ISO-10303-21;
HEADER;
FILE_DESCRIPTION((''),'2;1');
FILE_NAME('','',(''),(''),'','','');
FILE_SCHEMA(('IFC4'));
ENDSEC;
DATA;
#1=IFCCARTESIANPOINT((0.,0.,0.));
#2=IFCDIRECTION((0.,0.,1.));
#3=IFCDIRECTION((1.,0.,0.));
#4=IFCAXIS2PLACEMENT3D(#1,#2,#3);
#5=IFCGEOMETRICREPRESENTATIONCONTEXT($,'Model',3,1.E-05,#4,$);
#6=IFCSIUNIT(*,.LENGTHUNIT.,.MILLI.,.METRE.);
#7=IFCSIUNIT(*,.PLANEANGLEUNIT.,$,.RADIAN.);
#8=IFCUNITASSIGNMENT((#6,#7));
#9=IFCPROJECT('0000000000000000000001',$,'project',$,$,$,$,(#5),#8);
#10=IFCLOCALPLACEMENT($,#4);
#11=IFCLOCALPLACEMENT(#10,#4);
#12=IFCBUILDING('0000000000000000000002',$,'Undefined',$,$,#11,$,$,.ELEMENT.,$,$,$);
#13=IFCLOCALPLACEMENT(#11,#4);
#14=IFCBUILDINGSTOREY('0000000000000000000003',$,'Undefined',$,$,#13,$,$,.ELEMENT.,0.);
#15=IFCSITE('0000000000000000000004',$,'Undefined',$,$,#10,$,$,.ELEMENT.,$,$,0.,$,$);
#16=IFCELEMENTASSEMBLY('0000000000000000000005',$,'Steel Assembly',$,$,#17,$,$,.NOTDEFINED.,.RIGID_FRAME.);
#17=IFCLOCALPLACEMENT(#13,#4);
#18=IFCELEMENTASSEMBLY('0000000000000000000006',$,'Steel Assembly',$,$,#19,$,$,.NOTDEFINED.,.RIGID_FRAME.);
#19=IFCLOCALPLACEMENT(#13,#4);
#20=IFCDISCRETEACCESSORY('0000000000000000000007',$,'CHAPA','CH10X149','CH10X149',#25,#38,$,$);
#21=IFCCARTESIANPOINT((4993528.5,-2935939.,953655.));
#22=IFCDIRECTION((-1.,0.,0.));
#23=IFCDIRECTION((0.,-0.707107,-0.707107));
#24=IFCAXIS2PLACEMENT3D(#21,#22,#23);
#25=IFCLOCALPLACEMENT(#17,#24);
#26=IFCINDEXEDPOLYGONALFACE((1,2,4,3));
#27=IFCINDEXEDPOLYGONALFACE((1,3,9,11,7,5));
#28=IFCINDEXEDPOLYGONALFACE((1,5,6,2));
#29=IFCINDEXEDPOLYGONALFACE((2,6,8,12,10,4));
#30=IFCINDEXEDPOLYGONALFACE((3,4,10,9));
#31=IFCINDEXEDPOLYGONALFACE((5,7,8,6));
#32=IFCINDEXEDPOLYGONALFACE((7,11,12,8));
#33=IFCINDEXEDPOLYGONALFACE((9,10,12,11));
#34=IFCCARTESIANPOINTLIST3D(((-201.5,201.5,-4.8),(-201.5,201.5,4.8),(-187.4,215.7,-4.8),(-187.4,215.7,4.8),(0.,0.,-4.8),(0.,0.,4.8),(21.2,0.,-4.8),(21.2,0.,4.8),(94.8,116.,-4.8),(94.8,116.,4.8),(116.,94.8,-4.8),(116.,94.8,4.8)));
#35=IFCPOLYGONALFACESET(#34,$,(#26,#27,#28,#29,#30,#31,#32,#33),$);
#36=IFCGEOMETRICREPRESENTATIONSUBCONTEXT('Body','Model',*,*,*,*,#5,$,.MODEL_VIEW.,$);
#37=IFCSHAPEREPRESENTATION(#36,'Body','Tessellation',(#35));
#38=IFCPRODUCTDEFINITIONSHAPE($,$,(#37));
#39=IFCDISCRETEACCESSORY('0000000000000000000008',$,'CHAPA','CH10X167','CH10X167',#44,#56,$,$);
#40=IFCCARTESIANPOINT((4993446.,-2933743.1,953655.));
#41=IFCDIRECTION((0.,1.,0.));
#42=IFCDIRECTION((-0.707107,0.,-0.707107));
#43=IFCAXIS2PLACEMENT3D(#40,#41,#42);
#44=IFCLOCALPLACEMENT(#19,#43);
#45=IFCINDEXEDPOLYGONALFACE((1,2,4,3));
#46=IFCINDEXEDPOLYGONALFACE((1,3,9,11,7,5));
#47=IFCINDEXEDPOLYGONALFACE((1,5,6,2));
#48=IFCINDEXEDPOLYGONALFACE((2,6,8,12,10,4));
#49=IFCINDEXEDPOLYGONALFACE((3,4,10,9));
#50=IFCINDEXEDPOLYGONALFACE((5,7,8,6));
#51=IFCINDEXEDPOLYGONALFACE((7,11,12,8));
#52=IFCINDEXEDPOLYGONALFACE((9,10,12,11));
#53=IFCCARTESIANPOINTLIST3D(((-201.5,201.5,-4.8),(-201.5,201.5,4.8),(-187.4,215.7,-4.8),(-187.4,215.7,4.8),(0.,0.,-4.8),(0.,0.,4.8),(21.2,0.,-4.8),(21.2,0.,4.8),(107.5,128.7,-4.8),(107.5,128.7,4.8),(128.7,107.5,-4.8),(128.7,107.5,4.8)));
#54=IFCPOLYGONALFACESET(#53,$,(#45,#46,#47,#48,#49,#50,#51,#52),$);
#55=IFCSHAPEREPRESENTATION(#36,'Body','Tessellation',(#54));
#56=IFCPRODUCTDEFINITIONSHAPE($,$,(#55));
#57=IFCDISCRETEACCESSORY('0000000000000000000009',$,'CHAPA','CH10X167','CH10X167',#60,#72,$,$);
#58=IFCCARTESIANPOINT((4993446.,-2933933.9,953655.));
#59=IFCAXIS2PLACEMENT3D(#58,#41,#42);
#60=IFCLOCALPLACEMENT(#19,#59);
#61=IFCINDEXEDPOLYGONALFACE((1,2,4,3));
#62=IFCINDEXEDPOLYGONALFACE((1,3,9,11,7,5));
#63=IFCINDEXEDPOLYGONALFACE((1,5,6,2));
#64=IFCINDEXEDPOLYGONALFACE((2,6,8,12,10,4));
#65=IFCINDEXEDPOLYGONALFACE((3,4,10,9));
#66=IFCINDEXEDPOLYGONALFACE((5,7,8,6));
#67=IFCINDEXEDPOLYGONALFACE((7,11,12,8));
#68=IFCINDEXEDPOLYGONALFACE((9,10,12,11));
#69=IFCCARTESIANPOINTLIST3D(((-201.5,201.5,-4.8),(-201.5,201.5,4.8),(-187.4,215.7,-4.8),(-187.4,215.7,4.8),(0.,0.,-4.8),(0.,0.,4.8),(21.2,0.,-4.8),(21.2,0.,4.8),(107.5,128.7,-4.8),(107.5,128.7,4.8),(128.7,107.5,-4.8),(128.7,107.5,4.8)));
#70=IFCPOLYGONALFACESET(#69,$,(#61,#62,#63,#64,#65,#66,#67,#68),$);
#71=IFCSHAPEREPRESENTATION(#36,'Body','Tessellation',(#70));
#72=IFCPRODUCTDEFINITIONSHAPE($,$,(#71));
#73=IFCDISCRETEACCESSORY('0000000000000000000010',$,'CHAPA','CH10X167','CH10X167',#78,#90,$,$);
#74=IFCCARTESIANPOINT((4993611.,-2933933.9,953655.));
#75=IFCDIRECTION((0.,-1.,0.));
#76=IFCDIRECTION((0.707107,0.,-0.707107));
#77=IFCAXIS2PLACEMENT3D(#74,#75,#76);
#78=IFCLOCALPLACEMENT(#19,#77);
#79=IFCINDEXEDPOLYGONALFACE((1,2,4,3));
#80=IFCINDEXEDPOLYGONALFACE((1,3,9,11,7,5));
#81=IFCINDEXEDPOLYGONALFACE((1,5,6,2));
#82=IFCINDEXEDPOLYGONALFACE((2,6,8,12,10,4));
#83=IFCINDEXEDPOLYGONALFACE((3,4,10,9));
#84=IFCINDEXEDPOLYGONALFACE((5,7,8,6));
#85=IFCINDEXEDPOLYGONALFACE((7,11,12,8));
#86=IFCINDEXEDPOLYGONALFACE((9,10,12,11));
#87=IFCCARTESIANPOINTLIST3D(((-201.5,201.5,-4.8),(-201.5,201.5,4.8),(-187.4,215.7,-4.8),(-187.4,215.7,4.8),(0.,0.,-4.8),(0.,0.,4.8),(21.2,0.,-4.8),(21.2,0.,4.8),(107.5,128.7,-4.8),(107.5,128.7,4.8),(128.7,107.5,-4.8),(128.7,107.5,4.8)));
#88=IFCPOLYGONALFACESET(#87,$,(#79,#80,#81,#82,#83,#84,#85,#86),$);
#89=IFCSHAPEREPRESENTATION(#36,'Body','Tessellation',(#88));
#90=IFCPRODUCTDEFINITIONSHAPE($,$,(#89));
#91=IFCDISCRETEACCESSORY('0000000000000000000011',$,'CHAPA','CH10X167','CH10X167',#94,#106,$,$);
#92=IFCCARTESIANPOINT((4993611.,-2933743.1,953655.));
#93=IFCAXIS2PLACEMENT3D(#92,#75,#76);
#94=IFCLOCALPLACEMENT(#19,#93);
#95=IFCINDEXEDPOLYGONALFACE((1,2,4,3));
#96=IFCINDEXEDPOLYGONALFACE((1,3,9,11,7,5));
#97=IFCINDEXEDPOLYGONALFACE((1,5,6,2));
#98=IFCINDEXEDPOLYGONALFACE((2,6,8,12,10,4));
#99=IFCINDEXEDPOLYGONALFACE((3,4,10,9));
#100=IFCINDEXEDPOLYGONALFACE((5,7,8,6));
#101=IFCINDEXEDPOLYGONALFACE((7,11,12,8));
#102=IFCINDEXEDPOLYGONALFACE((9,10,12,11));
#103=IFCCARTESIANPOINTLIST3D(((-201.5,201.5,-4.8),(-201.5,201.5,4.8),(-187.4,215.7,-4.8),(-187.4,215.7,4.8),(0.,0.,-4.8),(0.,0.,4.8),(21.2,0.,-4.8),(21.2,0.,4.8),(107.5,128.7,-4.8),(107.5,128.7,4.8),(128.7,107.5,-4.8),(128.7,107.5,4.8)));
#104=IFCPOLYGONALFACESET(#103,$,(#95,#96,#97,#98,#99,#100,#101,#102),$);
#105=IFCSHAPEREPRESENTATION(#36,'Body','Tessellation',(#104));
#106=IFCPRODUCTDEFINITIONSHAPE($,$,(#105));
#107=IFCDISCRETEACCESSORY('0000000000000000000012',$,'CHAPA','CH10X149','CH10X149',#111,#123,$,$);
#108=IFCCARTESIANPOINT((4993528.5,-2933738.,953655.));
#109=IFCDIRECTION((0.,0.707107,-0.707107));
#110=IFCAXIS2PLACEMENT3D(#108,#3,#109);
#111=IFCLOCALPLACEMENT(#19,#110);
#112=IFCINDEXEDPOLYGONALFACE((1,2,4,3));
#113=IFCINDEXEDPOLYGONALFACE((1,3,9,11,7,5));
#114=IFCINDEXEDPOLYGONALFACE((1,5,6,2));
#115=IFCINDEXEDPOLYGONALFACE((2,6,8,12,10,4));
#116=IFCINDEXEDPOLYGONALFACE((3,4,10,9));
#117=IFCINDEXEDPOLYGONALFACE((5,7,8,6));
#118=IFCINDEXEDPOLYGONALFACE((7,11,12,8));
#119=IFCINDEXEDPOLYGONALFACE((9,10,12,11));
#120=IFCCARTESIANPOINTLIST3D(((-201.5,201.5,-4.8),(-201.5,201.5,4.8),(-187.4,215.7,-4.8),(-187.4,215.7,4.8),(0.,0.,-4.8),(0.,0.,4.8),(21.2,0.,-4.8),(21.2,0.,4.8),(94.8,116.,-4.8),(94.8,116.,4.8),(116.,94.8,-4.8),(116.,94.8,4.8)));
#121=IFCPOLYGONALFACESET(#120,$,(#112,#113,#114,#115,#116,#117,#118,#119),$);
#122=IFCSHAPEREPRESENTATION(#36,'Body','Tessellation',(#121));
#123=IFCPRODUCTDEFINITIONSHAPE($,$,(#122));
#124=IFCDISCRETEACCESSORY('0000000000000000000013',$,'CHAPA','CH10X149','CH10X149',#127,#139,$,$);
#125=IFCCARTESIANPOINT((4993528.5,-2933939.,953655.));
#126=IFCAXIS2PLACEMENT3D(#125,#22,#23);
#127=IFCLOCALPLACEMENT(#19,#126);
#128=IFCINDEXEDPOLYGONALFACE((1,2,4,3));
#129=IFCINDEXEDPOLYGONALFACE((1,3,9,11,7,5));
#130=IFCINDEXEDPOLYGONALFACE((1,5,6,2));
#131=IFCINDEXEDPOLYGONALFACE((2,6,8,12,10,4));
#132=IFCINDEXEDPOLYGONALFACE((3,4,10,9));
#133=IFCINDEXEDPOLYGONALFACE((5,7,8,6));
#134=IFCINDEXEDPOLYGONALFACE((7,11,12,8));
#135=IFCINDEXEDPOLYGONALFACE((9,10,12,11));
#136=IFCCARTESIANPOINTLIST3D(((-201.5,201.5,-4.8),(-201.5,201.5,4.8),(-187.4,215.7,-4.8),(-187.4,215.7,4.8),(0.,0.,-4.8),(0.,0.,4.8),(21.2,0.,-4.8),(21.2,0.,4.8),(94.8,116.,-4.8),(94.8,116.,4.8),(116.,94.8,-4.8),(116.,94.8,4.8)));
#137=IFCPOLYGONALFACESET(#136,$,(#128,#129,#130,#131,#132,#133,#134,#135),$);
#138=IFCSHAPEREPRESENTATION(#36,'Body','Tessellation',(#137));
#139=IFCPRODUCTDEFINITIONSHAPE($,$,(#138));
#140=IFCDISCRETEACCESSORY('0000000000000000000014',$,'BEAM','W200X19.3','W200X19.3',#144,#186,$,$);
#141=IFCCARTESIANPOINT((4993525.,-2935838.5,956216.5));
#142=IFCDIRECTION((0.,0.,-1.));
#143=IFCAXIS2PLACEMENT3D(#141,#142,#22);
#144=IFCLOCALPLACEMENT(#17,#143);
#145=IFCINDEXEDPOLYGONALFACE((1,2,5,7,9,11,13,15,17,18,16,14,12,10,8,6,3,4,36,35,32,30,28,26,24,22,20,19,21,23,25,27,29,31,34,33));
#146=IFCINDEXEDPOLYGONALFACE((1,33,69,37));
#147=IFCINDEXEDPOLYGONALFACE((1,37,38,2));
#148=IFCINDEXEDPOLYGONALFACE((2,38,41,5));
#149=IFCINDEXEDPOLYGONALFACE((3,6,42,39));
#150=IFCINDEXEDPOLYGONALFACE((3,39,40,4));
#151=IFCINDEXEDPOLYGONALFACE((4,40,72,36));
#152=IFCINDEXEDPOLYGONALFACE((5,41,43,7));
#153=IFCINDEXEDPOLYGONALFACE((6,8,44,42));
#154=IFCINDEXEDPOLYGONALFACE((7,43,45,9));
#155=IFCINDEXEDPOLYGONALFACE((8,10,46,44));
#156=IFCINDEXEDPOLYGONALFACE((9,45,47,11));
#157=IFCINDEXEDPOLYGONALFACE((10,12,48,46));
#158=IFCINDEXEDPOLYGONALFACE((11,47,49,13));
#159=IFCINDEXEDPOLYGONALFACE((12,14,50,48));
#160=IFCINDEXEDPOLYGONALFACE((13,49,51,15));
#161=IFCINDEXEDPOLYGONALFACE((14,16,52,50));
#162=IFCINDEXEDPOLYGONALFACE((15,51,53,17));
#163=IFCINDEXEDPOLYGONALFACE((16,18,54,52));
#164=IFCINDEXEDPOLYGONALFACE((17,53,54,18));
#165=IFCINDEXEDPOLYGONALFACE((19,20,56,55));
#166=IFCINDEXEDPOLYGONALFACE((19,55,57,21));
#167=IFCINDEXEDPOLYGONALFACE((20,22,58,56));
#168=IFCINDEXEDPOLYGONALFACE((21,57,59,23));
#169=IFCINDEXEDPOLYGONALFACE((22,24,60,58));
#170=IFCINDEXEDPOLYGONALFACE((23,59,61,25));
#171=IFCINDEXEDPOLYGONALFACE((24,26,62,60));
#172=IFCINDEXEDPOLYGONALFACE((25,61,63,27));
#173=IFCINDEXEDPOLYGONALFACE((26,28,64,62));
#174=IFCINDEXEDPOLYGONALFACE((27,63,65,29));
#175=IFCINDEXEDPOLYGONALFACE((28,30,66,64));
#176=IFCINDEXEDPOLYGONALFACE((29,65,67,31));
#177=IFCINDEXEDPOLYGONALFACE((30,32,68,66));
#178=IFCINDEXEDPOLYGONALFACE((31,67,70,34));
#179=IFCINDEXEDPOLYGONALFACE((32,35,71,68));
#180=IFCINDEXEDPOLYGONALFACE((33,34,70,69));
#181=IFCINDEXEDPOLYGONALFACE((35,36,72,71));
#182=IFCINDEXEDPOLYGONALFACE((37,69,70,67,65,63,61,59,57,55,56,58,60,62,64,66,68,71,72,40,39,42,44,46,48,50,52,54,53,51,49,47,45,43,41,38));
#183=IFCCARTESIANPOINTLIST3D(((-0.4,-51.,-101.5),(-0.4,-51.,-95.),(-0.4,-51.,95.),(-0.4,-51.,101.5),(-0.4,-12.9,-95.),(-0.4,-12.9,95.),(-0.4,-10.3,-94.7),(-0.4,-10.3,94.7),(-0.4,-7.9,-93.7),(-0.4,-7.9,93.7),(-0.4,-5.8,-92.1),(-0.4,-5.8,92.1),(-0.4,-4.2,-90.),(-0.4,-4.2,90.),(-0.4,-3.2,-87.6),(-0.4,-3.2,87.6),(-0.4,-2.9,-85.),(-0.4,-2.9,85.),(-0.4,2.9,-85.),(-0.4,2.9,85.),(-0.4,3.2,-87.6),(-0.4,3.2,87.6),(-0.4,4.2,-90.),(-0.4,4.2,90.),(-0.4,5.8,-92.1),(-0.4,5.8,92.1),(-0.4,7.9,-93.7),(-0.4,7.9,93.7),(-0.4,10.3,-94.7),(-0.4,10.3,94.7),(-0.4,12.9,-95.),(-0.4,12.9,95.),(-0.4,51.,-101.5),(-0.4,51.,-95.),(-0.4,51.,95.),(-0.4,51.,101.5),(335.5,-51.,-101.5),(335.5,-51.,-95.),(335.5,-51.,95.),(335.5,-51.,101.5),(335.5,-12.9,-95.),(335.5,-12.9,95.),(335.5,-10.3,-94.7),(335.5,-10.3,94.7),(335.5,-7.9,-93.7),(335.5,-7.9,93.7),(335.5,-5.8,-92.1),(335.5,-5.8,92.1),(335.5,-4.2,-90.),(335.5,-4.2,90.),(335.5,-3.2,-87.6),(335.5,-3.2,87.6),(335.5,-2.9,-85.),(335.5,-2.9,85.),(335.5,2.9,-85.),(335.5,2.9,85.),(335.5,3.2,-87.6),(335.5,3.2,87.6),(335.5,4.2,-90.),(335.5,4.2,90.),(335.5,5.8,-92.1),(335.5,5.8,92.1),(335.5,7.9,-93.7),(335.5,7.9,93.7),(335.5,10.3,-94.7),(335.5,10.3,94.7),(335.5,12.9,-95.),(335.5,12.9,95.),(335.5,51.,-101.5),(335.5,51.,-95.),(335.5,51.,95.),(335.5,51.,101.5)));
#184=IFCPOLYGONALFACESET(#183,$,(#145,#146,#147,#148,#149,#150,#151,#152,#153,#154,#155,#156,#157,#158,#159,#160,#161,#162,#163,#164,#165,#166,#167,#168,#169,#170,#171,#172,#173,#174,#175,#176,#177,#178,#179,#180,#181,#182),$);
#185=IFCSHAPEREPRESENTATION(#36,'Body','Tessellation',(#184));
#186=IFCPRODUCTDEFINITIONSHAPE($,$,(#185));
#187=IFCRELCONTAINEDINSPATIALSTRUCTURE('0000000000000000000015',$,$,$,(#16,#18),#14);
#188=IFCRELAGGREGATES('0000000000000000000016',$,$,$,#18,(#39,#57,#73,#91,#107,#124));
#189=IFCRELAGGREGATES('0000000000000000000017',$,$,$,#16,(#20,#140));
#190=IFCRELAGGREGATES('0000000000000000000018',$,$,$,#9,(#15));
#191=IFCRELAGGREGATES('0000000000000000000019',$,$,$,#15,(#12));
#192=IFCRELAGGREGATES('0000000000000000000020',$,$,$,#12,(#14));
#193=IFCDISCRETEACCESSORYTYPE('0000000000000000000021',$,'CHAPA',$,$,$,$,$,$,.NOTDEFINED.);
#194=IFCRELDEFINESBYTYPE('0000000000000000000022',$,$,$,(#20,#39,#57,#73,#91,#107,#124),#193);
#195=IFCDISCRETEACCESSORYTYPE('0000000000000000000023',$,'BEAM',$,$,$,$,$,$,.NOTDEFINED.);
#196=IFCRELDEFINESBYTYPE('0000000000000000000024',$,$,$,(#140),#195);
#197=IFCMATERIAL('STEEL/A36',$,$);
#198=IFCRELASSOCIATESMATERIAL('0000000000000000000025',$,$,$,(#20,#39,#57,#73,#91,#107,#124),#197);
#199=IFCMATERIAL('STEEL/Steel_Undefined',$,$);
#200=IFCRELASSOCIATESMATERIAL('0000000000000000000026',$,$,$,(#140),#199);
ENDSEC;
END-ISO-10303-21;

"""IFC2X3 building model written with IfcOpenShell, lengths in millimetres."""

from ifc_helpers import new_model, si_unit, frame, origin_with_axes, origin_2d_with_axis, place, context, subcontext, project, spatial, polyline, i_section, outline, extrude, clip, halfspace, material, type_object, element, aggregate, save


model = new_model("IFC2X3")

# Units and contexts
model_context = context("Model", 3, precision=1e-05, world=origin_with_axes())
body_context = subcontext(model_context, "Body", "Model", "MODEL_VIEW")
ifc_project = project(units=[si_unit("LENGTHUNIT", "METRE", prefix="MILLI"), si_unit("PLANEANGLEUNIT", "RADIAN")], contexts=[model_context])

# Site, building, storey
site_placement = place(None, origin_with_axes())
site = spatial("IfcSite", under=ifc_project, at=site_placement, Name="Undefined", CompositionType="ELEMENT", RefElevation=0.0)
building_placement = place(site_placement, origin_with_axes())
building = spatial("IfcBuilding", under=site, at=building_placement, Name="Undefined", CompositionType="ELEMENT")
storey_placement = place(building_placement, origin_with_axes())
storey = spatial("IfcBuildingStorey", under=building, at=storey_placement, Name="Undefined", CompositionType="ELEMENT", Elevation=0.0)

# Element assemblies
assembly_1_placement = place(storey_placement, origin_with_axes())
assembly_1 = element("IfcElementAssembly", 1, at=assembly_1_placement, inside=storey, Name="Steel Assembly", AssemblyPlace="NOTDEFINED", PredefinedType="RIGID_FRAME")
assembly_2_placement = place(storey_placement, origin_with_axes())
assembly_2 = element("IfcElementAssembly", 2, at=assembly_2_placement, inside=storey, Name="Steel Assembly", AssemblyPlace="NOTDEFINED", PredefinedType="RIGID_FRAME")

# Shared definitions
ifc_material_1 = material(Name="STEEL/Steel_Undefined")

# Discrete accessories
ifc_material_2 = material(Name="STEEL/A36")
discrete_accessory_type_1 = type_object("IfcDiscreteAccessoryType", Name="CHAPA")
discrete_accessory_1_placement = place(assembly_1_placement, frame((4993528.5, -2935939.0, 953655.0), z_axis=(-1.0, 0.0, 0.0), x_axis=(0.0, -0.707107, -0.707107)))
discrete_accessory_1 = element("IfcDiscreteAccessory", 3, at=discrete_accessory_1_placement, type_object=discrete_accessory_type_1, material=ifc_material_2, Name="CHAPA", Description="CH10X149", ObjectType="CH10X149", context=body_context, shape_type="SweptSolid", body=[
    extrude(outline(polyline([(0.0, 0.0), (21.2, 0.0), (116.0, 94.8), (94.8, 116.0), (-187.4, 215.7), (-201.5, 201.5), (0.0, 0.0)])), frame((0.0, 0.0, -4.8), z_axis=(0.0, 0.0, 1.0), x_axis=(1.0, 0.0, 0.0)), (0.0, 0.0, 1.0), 9.5),
])
discrete_accessory_2_placement = place(assembly_2_placement, frame((4993446.0, -2933743.1, 953655.0), z_axis=(0.0, 1.0, 0.0), x_axis=(-0.707107, 0.0, -0.707107)))
discrete_accessory_2 = element("IfcDiscreteAccessory", 4, at=discrete_accessory_2_placement, type_object=discrete_accessory_type_1, material=ifc_material_2, Name="CHAPA", Description="CH10X167", ObjectType="CH10X167", context=body_context, shape_type="SweptSolid", body=[
    extrude(outline(polyline([(0.0, 0.0), (21.2, 0.0), (128.7, 107.5), (107.5, 128.7), (-187.4, 215.7), (-201.5, 201.5), (0.0, 0.0)])), frame((0.0, 0.0, -4.8), z_axis=(0.0, 0.0, 1.0), x_axis=(1.0, 0.0, 0.0)), (0.0, 0.0, 1.0), 9.5),
])
discrete_accessory_3_placement = place(assembly_2_placement, frame((4993446.0, -2933933.9, 953655.0), z_axis=(0.0, 1.0, 0.0), x_axis=(-0.707107, 0.0, -0.707107)))
discrete_accessory_3 = element("IfcDiscreteAccessory", 5, at=discrete_accessory_3_placement, type_object=discrete_accessory_type_1, material=ifc_material_2, Name="CHAPA", Description="CH10X167", ObjectType="CH10X167", context=body_context, shape_type="SweptSolid", body=[
    extrude(outline(polyline([(0.0, 0.0), (21.2, 0.0), (128.7, 107.5), (107.5, 128.7), (-187.4, 215.7), (-201.5, 201.5), (0.0, 0.0)])), frame((0.0, 0.0, -4.8), z_axis=(0.0, 0.0, 1.0), x_axis=(1.0, 0.0, 0.0)), (0.0, 0.0, 1.0), 9.5),
])
discrete_accessory_4_placement = place(assembly_2_placement, frame((4993611.0, -2933933.9, 953655.0), z_axis=(0.0, -1.0, 0.0), x_axis=(0.707107, 0.0, -0.707107)))
discrete_accessory_4 = element("IfcDiscreteAccessory", 6, at=discrete_accessory_4_placement, type_object=discrete_accessory_type_1, material=ifc_material_2, Name="CHAPA", Description="CH10X167", ObjectType="CH10X167", context=body_context, shape_type="SweptSolid", body=[
    extrude(outline(polyline([(0.0, 0.0), (21.2, 0.0), (128.7, 107.5), (107.5, 128.7), (-187.4, 215.7), (-201.5, 201.5), (0.0, 0.0)])), frame((0.0, 0.0, -4.8), z_axis=(0.0, 0.0, 1.0), x_axis=(1.0, 0.0, 0.0)), (0.0, 0.0, 1.0), 9.5),
])
discrete_accessory_5_placement = place(assembly_2_placement, frame((4993611.0, -2933743.1, 953655.0), z_axis=(0.0, -1.0, 0.0), x_axis=(0.707107, 0.0, -0.707107)))
discrete_accessory_5 = element("IfcDiscreteAccessory", 7, at=discrete_accessory_5_placement, type_object=discrete_accessory_type_1, material=ifc_material_2, Name="CHAPA", Description="CH10X167", ObjectType="CH10X167", context=body_context, shape_type="SweptSolid", body=[
    extrude(outline(polyline([(0.0, 0.0), (21.2, 0.0), (128.7, 107.5), (107.5, 128.7), (-187.4, 215.7), (-201.5, 201.5), (0.0, 0.0)])), frame((0.0, 0.0, -4.8), z_axis=(0.0, 0.0, 1.0), x_axis=(1.0, 0.0, 0.0)), (0.0, 0.0, 1.0), 9.5),
])
discrete_accessory_6_placement = place(assembly_2_placement, frame((4993528.5, -2933738.0, 953655.0), z_axis=(1.0, 0.0, 0.0), x_axis=(0.0, 0.707107, -0.707107)))
discrete_accessory_6 = element("IfcDiscreteAccessory", 8, at=discrete_accessory_6_placement, type_object=discrete_accessory_type_1, material=ifc_material_2, Name="CHAPA", Description="CH10X149", ObjectType="CH10X149", context=body_context, shape_type="SweptSolid", body=[
    extrude(outline(polyline([(0.0, 0.0), (21.2, 0.0), (116.0, 94.8), (94.8, 116.0), (-187.4, 215.7), (-201.5, 201.5), (0.0, 0.0)])), frame((0.0, 0.0, -4.8), z_axis=(0.0, 0.0, 1.0), x_axis=(1.0, 0.0, 0.0)), (0.0, 0.0, 1.0), 9.5),
])
discrete_accessory_7_placement = place(assembly_2_placement, frame((4993528.5, -2933939.0, 953655.0), z_axis=(-1.0, 0.0, 0.0), x_axis=(0.0, -0.707107, -0.707107)))
discrete_accessory_7 = element("IfcDiscreteAccessory", 9, at=discrete_accessory_7_placement, type_object=discrete_accessory_type_1, material=ifc_material_2, Name="CHAPA", Description="CH10X149", ObjectType="CH10X149", context=body_context, shape_type="SweptSolid", body=[
    extrude(outline(polyline([(0.0, 0.0), (21.2, 0.0), (116.0, 94.8), (94.8, 116.0), (-187.4, 215.7), (-201.5, 201.5), (0.0, 0.0)])), frame((0.0, 0.0, -4.8), z_axis=(0.0, 0.0, 1.0), x_axis=(1.0, 0.0, 0.0)), (0.0, 0.0, 1.0), 9.5),
])
aggregate(assembly_2, [discrete_accessory_2, discrete_accessory_3, discrete_accessory_4, discrete_accessory_5, discrete_accessory_6, discrete_accessory_7])

# Discrete accessory
discrete_accessory_type_2 = type_object("IfcDiscreteAccessoryType", Name="BEAM")
discrete_accessory_8_placement = place(assembly_1_placement, frame((4993525.0, -2935838.5, 956216.5), z_axis=(0.0, 0.0, -1.0), x_axis=(-1.0, 0.0, 0.0)))
discrete_accessory_8 = element("IfcDiscreteAccessory", 10, at=discrete_accessory_8_placement, type_object=discrete_accessory_type_2, material=ifc_material_1, Name="BEAM", Description="W200X19.3", ObjectType="W200X19.3", context=body_context, shape_type="Clipping", body=[
    clip(clip(extrude(i_section(OverallWidth=102.0, OverallDepth=203.0, WebThickness=5.8, FlangeThickness=6.5, FilletRadius=10.0, at=origin_2d_with_axis()), frame((335.5, 0.0, 0.0), z_axis=(-1.0, 0.0, 0.0), x_axis=(0.0, -1.0, 0.0)), (0.0, 0.0, 1.0), 335.9), halfspace(frame((335.5, 0.0, -1000.0), z_axis=(-1.0, 0.0, 0.0), x_axis=(0.0, 1.0, 0.0)), True)), halfspace(frame((-0.4, 0.0, -1101.5), z_axis=(-1.0, 0.0, 0.0), x_axis=(0.0, 1.0, 0.0)), False)),
])
aggregate(assembly_1, [discrete_accessory_1, discrete_accessory_8])

save(model, "model.ifc")
